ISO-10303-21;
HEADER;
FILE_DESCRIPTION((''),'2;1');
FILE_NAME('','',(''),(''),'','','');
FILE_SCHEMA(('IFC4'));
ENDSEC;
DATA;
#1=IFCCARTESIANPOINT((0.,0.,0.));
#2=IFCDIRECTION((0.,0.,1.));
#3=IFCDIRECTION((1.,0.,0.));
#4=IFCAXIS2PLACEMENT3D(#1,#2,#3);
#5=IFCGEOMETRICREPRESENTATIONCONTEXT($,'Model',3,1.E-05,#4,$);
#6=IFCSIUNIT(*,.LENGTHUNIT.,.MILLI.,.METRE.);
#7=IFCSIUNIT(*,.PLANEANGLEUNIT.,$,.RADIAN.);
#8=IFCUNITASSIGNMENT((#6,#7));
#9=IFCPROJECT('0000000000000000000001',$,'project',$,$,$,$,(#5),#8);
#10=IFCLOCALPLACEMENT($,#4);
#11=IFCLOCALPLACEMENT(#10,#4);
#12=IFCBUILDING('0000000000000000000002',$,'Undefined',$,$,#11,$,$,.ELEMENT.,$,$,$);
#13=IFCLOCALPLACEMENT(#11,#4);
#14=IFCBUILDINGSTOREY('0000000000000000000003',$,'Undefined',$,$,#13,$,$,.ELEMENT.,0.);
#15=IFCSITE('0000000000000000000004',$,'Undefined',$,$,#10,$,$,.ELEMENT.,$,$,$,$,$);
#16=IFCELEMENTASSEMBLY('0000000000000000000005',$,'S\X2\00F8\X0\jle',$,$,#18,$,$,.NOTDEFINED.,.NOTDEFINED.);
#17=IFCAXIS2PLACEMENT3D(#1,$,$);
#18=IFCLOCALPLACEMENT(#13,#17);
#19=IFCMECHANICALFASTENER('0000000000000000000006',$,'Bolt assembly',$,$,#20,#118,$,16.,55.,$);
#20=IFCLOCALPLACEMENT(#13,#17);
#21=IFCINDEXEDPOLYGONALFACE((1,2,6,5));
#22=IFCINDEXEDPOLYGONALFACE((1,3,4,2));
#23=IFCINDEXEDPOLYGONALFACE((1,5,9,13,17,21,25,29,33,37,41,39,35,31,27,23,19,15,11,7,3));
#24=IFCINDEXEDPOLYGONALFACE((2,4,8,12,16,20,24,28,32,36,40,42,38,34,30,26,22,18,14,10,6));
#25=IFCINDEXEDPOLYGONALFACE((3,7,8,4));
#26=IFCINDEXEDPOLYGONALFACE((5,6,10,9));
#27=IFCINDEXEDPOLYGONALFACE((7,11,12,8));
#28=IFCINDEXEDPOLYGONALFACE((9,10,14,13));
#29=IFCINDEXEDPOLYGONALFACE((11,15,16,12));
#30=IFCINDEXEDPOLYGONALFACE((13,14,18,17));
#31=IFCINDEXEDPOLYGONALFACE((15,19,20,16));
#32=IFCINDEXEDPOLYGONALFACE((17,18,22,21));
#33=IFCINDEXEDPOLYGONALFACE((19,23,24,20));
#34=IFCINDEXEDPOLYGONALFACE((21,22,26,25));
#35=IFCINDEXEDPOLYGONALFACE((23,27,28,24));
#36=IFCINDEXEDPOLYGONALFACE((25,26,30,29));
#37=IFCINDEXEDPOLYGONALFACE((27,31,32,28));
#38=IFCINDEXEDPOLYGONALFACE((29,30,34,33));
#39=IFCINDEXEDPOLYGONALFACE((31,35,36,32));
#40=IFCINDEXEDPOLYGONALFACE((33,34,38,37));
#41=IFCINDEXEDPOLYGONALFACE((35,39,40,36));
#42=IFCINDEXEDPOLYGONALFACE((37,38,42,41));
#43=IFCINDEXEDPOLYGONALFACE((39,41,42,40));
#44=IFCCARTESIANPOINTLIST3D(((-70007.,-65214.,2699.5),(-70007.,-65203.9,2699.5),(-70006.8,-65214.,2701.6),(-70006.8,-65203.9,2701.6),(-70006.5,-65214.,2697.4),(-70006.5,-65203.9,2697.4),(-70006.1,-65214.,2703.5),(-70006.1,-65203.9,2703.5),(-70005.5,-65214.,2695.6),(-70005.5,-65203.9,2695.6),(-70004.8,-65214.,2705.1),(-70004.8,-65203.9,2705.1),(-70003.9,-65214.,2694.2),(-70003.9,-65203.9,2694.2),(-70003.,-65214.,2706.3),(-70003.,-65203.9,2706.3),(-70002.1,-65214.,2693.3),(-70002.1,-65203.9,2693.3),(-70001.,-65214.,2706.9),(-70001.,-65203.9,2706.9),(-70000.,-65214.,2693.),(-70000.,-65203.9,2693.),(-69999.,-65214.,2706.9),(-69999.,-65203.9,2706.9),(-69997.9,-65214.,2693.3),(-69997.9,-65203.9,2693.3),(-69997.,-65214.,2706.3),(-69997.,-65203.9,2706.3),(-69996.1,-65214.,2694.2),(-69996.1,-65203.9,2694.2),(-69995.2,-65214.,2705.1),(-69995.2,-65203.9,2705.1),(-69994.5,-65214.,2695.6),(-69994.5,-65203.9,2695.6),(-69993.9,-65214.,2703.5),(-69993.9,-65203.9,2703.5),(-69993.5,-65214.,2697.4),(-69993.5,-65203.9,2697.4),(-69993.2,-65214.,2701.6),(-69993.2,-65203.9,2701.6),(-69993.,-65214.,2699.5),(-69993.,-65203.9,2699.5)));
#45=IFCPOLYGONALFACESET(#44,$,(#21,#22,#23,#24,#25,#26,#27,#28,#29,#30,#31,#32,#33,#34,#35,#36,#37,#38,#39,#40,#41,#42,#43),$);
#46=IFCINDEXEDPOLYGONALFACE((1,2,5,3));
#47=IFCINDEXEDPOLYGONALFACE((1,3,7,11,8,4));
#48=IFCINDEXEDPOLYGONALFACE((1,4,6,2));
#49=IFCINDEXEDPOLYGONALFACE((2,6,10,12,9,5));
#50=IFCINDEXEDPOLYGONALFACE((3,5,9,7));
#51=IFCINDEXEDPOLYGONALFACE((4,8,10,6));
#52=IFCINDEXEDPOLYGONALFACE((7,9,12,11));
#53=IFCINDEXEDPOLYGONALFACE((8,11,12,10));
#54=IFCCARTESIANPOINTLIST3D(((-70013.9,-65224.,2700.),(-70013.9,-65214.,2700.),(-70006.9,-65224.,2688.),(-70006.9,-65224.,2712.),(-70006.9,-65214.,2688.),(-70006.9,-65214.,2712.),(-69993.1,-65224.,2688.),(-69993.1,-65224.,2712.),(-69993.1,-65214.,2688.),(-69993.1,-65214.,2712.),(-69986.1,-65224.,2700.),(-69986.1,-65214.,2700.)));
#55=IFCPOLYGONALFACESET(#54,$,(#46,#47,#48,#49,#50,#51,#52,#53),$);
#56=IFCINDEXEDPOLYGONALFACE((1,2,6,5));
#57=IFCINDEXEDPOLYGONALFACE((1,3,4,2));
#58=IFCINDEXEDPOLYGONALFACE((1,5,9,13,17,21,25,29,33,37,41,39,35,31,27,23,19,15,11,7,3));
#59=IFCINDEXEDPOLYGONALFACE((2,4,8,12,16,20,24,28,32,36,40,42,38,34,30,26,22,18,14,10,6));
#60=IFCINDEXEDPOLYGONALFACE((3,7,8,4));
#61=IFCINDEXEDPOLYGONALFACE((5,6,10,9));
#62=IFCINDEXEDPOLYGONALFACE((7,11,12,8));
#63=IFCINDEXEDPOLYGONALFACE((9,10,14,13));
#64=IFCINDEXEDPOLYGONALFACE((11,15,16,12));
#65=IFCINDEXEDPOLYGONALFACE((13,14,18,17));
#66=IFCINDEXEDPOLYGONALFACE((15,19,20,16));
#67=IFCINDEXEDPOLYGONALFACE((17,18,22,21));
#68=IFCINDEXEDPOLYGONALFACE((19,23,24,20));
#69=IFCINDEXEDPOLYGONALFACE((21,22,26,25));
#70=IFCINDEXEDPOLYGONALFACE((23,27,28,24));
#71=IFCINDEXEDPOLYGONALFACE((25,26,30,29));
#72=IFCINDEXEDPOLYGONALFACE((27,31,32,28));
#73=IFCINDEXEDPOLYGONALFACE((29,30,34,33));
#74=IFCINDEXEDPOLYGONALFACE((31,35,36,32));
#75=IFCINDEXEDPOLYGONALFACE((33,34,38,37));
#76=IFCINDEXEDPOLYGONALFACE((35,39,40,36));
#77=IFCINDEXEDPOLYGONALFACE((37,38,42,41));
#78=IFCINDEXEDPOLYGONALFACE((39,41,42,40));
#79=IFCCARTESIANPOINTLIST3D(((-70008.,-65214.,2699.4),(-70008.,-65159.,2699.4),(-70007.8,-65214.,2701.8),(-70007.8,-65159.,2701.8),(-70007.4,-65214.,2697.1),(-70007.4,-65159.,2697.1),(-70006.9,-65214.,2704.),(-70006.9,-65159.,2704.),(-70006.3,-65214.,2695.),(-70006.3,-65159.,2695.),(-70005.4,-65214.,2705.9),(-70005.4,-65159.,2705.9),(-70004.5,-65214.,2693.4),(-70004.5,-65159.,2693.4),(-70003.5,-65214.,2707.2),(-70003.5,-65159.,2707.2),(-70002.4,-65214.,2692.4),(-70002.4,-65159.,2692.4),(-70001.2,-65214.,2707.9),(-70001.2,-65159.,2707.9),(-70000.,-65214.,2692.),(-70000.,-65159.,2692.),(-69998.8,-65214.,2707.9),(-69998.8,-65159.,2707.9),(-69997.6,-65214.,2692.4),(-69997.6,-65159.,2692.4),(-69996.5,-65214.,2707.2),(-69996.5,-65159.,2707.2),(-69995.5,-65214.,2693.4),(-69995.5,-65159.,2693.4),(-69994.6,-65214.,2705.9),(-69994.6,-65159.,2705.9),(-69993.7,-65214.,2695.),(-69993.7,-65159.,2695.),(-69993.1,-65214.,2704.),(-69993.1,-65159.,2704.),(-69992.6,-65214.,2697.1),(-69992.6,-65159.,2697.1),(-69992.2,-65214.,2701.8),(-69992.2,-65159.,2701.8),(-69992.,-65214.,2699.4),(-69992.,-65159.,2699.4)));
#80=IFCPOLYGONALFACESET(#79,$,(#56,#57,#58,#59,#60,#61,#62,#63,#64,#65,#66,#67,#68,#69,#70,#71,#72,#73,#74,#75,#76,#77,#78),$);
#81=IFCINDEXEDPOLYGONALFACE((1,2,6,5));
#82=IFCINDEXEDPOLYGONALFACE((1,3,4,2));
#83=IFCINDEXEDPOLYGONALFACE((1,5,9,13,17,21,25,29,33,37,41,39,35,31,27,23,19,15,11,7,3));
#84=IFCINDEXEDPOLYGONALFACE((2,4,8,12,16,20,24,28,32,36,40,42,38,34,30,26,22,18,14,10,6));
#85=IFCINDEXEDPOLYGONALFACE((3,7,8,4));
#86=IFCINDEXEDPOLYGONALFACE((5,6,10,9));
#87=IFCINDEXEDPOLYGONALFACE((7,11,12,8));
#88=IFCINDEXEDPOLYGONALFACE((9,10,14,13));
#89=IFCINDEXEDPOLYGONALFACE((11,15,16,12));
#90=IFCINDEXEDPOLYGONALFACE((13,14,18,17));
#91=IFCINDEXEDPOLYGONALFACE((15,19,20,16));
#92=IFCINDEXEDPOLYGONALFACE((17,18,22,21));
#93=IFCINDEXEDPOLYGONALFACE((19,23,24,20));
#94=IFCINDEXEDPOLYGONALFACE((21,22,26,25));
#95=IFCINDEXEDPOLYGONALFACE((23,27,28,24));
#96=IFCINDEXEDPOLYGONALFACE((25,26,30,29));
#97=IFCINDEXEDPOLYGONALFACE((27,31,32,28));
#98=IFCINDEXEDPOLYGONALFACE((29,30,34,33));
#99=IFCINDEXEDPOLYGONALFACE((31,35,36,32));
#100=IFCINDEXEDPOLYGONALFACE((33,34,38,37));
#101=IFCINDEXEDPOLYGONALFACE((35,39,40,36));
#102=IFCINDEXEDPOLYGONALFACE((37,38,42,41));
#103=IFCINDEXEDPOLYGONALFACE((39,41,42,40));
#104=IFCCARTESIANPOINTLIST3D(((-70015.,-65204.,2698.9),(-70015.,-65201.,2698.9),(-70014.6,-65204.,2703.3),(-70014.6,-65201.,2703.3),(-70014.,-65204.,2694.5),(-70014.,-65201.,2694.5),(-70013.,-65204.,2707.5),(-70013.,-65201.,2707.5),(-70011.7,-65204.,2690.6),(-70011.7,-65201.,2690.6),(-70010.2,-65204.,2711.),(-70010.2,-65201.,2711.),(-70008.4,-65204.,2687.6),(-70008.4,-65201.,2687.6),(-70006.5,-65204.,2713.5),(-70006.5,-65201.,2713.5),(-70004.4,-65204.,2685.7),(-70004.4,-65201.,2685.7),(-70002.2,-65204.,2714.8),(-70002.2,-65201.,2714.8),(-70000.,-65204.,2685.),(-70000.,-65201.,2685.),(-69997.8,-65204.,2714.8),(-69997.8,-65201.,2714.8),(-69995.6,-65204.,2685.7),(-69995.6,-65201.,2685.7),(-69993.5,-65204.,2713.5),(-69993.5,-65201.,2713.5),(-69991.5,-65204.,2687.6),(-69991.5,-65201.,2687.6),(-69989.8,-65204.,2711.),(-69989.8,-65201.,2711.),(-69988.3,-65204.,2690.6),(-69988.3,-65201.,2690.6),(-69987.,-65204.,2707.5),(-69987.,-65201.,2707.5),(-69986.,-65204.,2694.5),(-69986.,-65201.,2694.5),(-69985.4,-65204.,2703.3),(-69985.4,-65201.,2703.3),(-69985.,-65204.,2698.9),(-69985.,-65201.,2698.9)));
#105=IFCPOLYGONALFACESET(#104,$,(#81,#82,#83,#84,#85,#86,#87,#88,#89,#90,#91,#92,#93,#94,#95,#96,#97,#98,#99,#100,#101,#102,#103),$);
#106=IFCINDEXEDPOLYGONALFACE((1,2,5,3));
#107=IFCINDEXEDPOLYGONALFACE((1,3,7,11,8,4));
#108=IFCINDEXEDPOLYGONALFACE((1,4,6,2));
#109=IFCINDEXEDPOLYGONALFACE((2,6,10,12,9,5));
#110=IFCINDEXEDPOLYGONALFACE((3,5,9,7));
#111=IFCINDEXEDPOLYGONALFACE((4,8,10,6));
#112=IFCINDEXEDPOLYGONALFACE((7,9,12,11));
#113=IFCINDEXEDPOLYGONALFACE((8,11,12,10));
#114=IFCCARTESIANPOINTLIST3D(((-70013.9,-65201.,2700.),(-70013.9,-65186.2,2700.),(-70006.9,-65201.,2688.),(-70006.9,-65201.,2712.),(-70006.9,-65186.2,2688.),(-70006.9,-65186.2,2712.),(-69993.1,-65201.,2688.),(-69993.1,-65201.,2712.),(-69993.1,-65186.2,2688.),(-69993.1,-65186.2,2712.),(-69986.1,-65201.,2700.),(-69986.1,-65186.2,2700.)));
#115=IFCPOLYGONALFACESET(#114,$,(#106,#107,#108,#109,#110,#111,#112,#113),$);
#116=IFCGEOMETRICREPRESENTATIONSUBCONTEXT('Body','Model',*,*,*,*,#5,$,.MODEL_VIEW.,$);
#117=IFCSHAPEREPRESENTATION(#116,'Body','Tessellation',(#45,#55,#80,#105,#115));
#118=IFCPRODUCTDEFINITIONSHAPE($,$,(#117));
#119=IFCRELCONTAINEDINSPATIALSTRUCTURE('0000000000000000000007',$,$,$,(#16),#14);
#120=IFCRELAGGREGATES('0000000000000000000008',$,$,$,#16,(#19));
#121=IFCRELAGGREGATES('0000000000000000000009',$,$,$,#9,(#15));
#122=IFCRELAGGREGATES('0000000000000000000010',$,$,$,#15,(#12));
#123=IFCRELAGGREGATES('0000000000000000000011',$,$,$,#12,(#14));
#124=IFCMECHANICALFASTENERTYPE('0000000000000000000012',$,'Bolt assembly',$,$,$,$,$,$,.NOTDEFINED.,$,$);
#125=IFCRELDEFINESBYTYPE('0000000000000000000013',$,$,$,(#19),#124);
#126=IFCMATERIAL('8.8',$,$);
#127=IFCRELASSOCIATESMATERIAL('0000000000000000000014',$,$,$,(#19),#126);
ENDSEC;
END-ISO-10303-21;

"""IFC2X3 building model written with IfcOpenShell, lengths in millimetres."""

from ifc_helpers import new_model, si_unit, frame, origin_with_axes, origin_2d_with_axis, place, context, subcontext, project, spatial, polyline, circle, outline, extrude, source, transform, mapped, material, type_object, element, aggregate, save


model = new_model("IFC2X3")

# Units and contexts
model_context = context("Model", 3, precision=1e-05, world=origin_with_axes())
body_context = subcontext(model_context, "Body", "Model", "MODEL_VIEW")
ifc_project = project(units=[si_unit("LENGTHUNIT", "METRE", prefix="MILLI"), si_unit("PLANEANGLEUNIT", "RADIAN")], contexts=[model_context])

# Site, building, storey
site_placement = place(None, origin_with_axes())
site = spatial("IfcSite", under=ifc_project, at=site_placement, Name="Undefined", CompositionType="ELEMENT")
building_placement = place(site_placement, origin_with_axes())
building = spatial("IfcBuilding", under=site, at=building_placement, Name="Undefined", CompositionType="ELEMENT")
storey_placement = place(building_placement, origin_with_axes())
storey = spatial("IfcBuildingStorey", under=building, at=storey_placement, Name="Undefined", CompositionType="ELEMENT", Elevation=0.0)

# Element assembly
assembly_1_placement = place(storey_placement, origin_with_axes())
assembly_1 = element("IfcElementAssembly", 1, at=assembly_1_placement, inside=storey, Name="Søjle", AssemblyPlace="NOTDEFINED", PredefinedType="NOTDEFINED")

# Shared definitions
ifc_material_1 = material(Name="8.8")
mechanical_fastener_type = type_object("IfcMechanicalFastenerType", Name="Bolt assembly")

# Mechanical fastener
shared_shape_1 = source(origin_with_axes(), body_context, "Body", "SweptSolid", [
    extrude(circle(Radius=7.0, at=origin_2d_with_axis()), frame((0.0, 0.0, 0.0), z_axis=(0.0, 1.0, 0.0), x_axis=(1.0, 0.0, 0.0)), (0.0, 0.0, 1.0), 10.1),
    extrude(outline(polyline([(12.0, -6.9), (12.0, 6.9), (0.0, 13.9), (-12.0, 6.9), (-12.0, -6.9), (0.0, -13.9), (12.0, -6.9)])), frame((0.0, -10.0, 0.0), z_axis=(0.0, 1.0, 0.0), x_axis=(1.0, 0.0, 0.0)), (0.0, 0.0, 1.0), 10.0),
    extrude(circle(Radius=8.0, at=origin_2d_with_axis()), frame((0.0, 0.0, 0.0), z_axis=(0.0, 1.0, 0.0), x_axis=(1.0, 0.0, 0.0)), (0.0, 0.0, 1.0), 55.0),
    extrude(circle(Radius=15.0, at=origin_2d_with_axis()), frame((0.0, 10.0, 0.0), z_axis=(0.0, 1.0, 0.0), x_axis=(1.0, 0.0, 0.0)), (0.0, 0.0, 1.0), 3.0),
    extrude(outline(polyline([(12.0, -6.9), (12.0, 6.9), (0.0, 13.9), (-12.0, 6.9), (-12.0, -6.9), (0.0, -13.9), (12.0, -6.9)])), frame((0.0, 13.0, 0.0), z_axis=(0.0, 1.0, 0.0), x_axis=(1.0, 0.0, 0.0)), (0.0, 0.0, 1.0), 14.8),
])
mechanical_fastener_1_placement = place(assembly_1_placement, frame((-70000.0, -65214.0, 2700.0), z_axis=(1.0, 0.0, 0.0), x_axis=(0.0, 0.0, -1.0)))
mechanical_fastener_1 = element("IfcMechanicalFastener", 2, at=mechanical_fastener_1_placement, type_object=mechanical_fastener_type, material=ifc_material_1, Name="Bolt assembly", NominalDiameter=16.0, NominalLength=55.0, context=body_context, shape_type="MappedRepresentation", body=[
    mapped(shared_shape_1, transform((0.0, 0.0, 0.0))),
])
aggregate(assembly_1, [mechanical_fastener_1])

save(model, "model.ifc")
